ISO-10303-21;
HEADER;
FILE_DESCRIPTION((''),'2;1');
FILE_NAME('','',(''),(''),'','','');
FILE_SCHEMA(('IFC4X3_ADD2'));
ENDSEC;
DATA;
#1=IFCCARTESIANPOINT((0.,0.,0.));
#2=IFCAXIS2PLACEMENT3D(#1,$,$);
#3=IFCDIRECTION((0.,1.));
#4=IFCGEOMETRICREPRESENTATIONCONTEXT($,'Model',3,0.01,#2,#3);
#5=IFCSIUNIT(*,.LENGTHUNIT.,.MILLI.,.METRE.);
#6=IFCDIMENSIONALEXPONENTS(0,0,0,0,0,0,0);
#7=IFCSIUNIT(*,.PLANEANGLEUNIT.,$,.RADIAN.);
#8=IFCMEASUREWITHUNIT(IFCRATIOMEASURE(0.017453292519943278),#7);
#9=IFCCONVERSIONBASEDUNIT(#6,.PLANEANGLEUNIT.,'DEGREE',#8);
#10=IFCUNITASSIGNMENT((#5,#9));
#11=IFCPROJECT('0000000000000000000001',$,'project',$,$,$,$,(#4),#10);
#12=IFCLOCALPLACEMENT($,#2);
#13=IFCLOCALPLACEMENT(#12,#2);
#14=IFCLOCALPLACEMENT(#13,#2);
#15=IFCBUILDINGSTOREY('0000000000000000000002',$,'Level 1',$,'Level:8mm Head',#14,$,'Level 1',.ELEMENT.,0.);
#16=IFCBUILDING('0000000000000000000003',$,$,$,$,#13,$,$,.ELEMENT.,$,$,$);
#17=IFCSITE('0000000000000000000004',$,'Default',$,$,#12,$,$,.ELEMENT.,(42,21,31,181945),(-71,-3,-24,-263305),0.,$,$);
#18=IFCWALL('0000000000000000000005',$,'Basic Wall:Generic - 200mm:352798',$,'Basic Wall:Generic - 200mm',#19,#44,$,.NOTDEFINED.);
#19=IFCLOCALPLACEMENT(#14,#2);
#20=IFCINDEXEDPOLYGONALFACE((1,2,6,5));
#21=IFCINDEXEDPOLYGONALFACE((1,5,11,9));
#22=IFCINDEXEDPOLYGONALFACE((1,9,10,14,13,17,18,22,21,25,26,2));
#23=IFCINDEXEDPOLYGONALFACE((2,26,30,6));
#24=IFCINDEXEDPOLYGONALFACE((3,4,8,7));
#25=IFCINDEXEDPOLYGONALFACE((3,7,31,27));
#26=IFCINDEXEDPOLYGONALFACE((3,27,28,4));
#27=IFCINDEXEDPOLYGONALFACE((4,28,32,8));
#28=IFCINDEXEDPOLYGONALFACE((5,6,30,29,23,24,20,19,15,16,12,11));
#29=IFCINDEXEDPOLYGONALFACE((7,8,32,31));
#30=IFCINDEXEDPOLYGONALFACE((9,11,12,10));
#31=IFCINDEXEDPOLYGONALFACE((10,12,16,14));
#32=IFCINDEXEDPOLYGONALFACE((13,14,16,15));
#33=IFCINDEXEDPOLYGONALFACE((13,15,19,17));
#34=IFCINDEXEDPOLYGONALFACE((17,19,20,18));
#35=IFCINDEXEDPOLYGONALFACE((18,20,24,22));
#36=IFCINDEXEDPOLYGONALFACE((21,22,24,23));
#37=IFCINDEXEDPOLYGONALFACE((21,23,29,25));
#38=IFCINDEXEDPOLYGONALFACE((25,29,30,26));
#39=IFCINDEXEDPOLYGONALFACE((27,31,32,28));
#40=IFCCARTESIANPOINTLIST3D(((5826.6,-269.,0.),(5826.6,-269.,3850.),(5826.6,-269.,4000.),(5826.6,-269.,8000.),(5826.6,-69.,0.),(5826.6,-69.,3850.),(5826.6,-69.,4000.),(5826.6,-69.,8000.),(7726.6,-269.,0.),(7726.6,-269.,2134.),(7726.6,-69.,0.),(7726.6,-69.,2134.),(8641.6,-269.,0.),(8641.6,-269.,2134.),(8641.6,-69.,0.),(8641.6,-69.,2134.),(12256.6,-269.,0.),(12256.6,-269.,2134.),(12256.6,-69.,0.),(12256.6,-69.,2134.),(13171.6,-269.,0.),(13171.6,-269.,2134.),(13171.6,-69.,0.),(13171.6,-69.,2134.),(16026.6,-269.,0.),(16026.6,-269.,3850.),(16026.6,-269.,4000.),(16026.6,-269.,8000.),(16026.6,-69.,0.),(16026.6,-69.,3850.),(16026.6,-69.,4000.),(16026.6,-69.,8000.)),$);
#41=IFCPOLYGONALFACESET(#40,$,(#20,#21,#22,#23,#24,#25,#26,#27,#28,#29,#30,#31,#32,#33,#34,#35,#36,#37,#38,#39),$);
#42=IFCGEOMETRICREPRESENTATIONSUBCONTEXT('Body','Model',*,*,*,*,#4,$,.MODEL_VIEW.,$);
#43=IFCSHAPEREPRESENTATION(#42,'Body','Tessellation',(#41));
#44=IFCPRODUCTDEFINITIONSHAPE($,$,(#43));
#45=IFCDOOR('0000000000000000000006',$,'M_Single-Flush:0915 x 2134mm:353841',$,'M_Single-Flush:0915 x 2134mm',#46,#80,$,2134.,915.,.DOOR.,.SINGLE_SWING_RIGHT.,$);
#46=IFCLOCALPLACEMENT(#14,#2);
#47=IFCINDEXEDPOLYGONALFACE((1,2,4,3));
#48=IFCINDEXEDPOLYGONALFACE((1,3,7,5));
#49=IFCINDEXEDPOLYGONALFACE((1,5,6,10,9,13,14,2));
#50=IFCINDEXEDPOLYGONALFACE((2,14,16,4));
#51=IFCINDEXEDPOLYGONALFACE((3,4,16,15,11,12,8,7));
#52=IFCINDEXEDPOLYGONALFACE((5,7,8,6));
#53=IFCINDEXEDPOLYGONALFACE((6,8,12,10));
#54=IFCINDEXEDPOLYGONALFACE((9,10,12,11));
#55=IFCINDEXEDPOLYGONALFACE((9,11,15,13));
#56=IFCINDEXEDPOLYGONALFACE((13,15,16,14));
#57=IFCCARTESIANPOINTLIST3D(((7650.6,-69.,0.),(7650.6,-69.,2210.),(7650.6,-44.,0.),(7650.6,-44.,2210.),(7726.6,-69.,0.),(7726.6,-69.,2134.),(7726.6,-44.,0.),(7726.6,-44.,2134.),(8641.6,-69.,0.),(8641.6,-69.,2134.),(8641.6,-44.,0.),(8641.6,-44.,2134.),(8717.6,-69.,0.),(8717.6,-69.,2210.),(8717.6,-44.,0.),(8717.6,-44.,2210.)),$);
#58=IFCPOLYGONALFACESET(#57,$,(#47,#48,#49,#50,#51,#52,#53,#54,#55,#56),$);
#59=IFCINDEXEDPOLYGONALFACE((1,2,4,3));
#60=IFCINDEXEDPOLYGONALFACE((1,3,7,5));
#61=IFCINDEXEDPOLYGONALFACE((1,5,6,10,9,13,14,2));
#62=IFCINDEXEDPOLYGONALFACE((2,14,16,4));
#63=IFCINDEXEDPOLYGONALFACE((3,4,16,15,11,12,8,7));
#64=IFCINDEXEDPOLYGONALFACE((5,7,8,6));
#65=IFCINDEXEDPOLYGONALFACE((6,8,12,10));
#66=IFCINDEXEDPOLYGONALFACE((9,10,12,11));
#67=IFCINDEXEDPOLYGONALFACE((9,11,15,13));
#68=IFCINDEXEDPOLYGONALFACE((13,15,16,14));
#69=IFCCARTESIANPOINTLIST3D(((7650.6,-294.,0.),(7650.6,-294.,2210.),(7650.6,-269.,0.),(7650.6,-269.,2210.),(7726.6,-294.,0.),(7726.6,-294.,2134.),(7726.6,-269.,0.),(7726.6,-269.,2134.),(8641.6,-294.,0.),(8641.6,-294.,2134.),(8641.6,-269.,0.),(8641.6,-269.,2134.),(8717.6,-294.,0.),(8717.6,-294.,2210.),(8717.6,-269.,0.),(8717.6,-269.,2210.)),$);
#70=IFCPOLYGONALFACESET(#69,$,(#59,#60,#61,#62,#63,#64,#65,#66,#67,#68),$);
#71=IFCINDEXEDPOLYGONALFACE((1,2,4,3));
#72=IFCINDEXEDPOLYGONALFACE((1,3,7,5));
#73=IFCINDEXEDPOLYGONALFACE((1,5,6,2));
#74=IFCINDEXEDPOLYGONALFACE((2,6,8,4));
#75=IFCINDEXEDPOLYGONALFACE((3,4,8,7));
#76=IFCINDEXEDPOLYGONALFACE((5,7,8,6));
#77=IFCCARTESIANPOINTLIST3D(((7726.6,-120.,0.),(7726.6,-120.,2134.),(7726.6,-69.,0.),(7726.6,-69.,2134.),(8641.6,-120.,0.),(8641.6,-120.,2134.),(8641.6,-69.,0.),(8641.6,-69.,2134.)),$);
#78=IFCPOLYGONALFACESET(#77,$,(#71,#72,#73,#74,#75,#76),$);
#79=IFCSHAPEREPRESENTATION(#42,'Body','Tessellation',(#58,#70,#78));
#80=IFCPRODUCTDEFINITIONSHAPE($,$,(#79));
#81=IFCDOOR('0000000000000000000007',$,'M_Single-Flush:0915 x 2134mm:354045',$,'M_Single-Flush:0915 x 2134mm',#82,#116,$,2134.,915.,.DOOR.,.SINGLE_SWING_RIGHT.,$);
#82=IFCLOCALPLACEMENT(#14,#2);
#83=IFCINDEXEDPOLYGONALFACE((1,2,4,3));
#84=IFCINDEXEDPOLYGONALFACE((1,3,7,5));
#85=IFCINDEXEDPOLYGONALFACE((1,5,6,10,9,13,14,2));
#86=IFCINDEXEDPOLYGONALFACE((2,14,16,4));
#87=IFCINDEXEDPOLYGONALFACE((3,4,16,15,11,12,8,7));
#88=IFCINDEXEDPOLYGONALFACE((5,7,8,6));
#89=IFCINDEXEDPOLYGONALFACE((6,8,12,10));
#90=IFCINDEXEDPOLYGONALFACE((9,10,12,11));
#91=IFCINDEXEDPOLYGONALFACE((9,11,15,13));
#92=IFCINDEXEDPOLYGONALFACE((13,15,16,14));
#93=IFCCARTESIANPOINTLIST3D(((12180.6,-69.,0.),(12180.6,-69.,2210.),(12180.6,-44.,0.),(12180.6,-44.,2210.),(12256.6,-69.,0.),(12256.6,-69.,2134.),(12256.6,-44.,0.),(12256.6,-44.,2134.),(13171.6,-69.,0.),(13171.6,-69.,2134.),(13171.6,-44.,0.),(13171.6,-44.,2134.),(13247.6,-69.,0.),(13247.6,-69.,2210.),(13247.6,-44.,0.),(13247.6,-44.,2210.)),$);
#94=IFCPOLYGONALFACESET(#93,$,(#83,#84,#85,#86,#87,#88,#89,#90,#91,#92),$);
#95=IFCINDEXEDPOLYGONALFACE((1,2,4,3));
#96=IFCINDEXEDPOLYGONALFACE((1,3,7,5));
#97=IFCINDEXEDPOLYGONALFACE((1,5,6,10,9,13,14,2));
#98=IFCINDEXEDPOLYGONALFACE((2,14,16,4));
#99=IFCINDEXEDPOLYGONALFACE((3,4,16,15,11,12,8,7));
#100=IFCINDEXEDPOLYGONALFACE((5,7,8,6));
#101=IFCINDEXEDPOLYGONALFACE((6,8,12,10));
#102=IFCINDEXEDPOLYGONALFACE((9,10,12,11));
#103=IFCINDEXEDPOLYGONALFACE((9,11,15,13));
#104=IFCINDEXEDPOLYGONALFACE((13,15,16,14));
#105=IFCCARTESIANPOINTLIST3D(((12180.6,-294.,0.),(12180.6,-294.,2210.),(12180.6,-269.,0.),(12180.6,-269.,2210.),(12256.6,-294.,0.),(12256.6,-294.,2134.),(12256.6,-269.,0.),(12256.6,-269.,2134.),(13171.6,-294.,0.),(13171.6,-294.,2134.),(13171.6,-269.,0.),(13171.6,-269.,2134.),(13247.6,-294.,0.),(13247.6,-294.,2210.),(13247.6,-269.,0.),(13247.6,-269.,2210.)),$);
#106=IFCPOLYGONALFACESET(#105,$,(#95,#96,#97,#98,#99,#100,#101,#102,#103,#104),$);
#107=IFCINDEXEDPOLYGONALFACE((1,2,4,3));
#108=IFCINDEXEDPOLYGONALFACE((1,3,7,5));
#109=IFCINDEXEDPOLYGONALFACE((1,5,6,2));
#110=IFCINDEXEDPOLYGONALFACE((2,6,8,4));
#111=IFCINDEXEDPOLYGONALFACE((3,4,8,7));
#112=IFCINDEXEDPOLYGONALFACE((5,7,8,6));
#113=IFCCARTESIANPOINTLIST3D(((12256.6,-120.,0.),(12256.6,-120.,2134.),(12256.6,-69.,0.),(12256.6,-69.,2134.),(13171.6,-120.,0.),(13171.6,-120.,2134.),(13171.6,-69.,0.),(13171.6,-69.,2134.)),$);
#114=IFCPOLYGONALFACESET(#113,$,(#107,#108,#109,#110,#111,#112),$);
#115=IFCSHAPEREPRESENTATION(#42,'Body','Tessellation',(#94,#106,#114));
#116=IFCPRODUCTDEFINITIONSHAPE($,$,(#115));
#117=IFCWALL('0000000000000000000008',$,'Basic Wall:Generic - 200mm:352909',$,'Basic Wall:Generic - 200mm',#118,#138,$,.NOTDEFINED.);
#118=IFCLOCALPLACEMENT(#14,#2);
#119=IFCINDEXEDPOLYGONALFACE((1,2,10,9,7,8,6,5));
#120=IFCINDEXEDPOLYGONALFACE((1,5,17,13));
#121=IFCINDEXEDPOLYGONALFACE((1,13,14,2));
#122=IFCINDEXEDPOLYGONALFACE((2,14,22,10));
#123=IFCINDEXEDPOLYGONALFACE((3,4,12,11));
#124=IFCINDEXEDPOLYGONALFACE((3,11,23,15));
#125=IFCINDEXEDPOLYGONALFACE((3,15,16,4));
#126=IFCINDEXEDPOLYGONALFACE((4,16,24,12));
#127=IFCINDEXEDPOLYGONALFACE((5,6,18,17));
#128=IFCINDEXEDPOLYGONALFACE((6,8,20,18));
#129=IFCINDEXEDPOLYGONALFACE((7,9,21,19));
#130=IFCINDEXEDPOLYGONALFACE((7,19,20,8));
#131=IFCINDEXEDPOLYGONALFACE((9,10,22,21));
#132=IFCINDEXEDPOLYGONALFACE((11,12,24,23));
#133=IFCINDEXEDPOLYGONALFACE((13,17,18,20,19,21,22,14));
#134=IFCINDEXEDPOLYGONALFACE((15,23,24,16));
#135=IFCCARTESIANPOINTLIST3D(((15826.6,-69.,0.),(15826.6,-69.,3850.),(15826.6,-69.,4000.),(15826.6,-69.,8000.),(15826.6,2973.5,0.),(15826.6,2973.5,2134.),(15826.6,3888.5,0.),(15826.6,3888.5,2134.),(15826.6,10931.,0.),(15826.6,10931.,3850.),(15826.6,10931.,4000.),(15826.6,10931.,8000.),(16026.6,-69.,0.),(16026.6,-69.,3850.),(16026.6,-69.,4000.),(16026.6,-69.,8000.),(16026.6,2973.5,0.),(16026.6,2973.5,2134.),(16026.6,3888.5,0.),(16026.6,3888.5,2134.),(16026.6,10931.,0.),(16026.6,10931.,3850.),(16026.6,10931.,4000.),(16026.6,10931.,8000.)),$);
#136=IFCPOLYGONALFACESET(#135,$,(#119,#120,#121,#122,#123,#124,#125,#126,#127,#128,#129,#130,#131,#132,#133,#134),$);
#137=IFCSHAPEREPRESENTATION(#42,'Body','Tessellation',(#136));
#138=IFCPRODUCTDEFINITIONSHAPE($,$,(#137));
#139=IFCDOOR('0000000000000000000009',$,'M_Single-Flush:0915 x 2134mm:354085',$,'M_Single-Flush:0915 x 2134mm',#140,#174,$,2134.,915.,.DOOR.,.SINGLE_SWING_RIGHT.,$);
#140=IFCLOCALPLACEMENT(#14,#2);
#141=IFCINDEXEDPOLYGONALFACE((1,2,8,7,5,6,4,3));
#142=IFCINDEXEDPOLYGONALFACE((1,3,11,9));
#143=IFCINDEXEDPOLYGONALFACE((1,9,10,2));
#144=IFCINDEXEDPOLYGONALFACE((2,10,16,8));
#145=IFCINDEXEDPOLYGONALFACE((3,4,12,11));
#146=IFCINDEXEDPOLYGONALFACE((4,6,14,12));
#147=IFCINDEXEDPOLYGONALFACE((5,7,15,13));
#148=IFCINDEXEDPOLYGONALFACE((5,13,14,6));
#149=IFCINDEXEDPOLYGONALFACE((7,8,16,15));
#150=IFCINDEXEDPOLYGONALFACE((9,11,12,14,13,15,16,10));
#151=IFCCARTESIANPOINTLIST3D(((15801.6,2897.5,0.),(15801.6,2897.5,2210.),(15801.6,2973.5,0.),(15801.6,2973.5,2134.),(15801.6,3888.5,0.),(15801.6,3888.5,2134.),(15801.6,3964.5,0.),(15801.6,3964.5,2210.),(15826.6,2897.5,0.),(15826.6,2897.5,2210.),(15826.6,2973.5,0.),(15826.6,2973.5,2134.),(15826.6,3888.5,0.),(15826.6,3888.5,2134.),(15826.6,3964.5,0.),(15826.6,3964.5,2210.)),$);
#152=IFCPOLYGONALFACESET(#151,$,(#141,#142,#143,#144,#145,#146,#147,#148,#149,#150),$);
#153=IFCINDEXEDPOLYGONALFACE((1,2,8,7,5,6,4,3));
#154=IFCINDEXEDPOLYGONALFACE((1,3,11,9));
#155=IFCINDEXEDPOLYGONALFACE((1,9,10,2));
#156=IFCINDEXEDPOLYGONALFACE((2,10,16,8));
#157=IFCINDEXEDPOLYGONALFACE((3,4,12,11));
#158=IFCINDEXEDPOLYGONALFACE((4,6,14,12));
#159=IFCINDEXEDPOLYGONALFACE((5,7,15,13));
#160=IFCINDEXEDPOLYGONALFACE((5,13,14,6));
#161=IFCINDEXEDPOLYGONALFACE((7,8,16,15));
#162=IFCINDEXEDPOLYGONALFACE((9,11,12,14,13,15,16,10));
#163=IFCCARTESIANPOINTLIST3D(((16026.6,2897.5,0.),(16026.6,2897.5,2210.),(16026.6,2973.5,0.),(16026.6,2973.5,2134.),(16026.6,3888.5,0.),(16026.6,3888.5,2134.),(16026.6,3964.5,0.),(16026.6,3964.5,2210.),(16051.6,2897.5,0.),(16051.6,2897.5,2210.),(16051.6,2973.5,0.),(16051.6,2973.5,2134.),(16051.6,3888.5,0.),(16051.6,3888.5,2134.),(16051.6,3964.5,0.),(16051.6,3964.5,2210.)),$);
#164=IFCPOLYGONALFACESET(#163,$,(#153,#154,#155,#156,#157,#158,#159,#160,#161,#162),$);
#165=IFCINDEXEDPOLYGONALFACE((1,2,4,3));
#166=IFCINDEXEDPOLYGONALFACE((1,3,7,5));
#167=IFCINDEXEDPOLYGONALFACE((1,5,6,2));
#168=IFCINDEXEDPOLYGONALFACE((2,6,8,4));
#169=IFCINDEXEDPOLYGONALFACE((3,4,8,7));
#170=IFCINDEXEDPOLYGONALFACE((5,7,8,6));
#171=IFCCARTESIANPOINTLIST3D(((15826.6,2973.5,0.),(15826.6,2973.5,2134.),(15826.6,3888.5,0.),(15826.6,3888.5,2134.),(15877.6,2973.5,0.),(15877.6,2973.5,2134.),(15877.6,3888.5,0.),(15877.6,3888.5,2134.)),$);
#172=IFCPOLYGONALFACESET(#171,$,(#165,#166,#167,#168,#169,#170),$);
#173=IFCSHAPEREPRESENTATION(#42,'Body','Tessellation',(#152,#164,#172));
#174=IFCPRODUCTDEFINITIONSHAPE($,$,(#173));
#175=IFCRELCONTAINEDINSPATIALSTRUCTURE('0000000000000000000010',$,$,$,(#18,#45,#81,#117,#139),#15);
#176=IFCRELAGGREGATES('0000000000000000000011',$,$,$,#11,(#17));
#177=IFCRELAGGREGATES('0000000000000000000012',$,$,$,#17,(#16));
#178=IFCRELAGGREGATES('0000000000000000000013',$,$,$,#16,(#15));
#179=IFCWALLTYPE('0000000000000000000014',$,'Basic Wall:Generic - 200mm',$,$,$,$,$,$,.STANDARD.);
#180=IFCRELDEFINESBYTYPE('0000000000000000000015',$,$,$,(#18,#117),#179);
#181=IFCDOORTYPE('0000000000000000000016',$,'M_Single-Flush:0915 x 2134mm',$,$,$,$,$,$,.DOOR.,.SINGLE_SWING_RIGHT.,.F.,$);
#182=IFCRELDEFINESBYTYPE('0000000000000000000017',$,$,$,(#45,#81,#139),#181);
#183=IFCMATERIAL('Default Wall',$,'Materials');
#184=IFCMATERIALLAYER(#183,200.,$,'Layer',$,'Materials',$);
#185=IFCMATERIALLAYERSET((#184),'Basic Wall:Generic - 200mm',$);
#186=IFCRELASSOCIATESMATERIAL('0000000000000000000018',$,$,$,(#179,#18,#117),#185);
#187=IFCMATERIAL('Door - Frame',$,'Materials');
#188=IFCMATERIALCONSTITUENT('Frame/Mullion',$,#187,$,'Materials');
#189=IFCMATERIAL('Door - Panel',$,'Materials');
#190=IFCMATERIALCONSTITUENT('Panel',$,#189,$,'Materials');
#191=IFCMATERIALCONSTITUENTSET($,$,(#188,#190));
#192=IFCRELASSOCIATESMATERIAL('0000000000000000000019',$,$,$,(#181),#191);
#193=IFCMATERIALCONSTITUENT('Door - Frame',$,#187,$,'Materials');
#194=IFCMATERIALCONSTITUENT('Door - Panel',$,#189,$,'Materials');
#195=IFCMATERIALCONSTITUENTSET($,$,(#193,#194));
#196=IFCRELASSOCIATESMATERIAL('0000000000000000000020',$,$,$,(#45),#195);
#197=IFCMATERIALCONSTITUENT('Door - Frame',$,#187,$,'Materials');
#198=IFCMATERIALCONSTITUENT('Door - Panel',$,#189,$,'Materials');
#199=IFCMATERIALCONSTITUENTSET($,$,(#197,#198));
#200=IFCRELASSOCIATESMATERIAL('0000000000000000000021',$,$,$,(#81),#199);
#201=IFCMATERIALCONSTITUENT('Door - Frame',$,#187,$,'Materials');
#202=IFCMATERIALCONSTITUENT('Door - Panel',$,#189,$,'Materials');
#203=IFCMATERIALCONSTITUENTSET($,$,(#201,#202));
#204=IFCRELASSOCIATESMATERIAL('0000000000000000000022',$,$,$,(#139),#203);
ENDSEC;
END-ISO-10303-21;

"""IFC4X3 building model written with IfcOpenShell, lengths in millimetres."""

from ifc_helpers import new_model, entity, si_unit, converted_unit, direction, frame, frame_2d, origin, place, context, subcontext, project, spatial, polyline, rectangle, outline, extrude, source, transform, mapped, material, layer, layer_set, constituent, constituent_set, type_object, type_shapes, element, fill, save


model = new_model("IFC4X3")

# Units and contexts
model_context = context("Model", 3, precision=0.01, world=origin(), true_north=direction((0.0, 1.0)))
body_context = subcontext(model_context, "Body", "Model", "MODEL_VIEW")
ifc_project = project(units=[si_unit("LENGTHUNIT", "METRE", prefix="MILLI"), converted_unit("PLANEANGLEUNIT", "DEGREE", entity("IfcRatioMeasure", 0.017453292519943278), si_unit("PLANEANGLEUNIT", "RADIAN"), dimensions=[0, 0, 0, 0, 0, 0, 0])], contexts=[model_context])

# Site, building, storey
site_placement = place(None, origin())
site = spatial("IfcSite", under=ifc_project, at=site_placement, Name="Default", CompositionType="ELEMENT", RefLatitude=(42, 21, 31, 181945), RefLongitude=(-71, -3, -24, -263305), RefElevation=0.0)
building_placement = place(site_placement, origin())
building = spatial("IfcBuilding", under=site, at=building_placement, CompositionType="ELEMENT")
storey_placement = place(building_placement, origin())
storey = spatial("IfcBuildingStorey", under=building, at=storey_placement, Name="Level 1", ObjectType="Level:8mm Head", LongName="Level 1", CompositionType="ELEMENT", Elevation=0.0)

# Wall, openings, doors
ifc_material_1 = material(Name="Default Wall", Category="Materials")
ifc_layer_1 = layer(ifc_material_1, 200.0, Name="Layer", Category="Materials")
ifc_layer_set_1 = layer_set([ifc_layer_1], Name="Basic Wall:Generic - 200mm")
wall_type = type_object("IfcWallType", Name="Basic Wall:Generic - 200mm", PredefinedType="STANDARD", material=ifc_layer_set_1)
wall_1_placement = place(storey_placement, frame((5826.6, -169.0, 0.0)))
wall_1 = element("IfcWall", 1, at=wall_1_placement, inside=storey, type_object=wall_type, material=ifc_layer_set_1, Name="Basic Wall:Generic - 200mm:352798", ObjectType="Basic Wall:Generic - 200mm", PredefinedType="NOTDEFINED", context=body_context, shape_type="SweptSolid", body=[
    extrude(rectangle(XDim=10200.0, YDim=200.0, at=frame_2d((5100.0, 0.0), x_axis=(-1.0, 0.0))), origin(), (0.0, 0.0, 1.0), 8000.0),
])
opening_1_placement = place(storey_placement, frame((5826.6, -169.0, 0.0)))
element("IfcOpeningElement", 2, at=opening_1_placement, cuts=wall_1, PredefinedType="OPENING", context=body_context, shape_type="SweptSolid", body=[
    extrude(rectangle(XDim=10200.0, YDim=200.0, at=frame_2d((0.0, -33.3), x_axis=(1.0, 0.0))), frame((5100.0, 33.3, 3850.0)), (0.0, 0.0, 1.0), 150.0),
])
opening_2_placement = place(wall_1_placement, frame((1900.0, -100.0, 0.0)))
opening_2 = element("IfcOpeningElement", 3, at=opening_2_placement, cuts=wall_1, PredefinedType="OPENING", context=body_context, shape_type="SweptSolid", body=[
    extrude(rectangle(XDim=915.0, YDim=2134.0, at=frame_2d((1067.0, 457.5), x_axis=(0.0, 1.0))), frame((0.0, 0.0, 0.0), z_axis=(0.0, 1.0, 0.0), x_axis=(0.0, 0.0, 1.0)), (0.0, 0.0, 1.0), 200.0),
])
opening_3_placement = place(wall_1_placement, frame((6430.0, -100.0, 0.0)))
opening_3 = element("IfcOpeningElement", 4, at=opening_3_placement, cuts=wall_1, PredefinedType="OPENING", context=body_context, shape_type="SweptSolid", body=[
    extrude(rectangle(XDim=915.0, YDim=2134.0, at=frame_2d((1067.0, 457.5), x_axis=(0.0, 1.0))), frame((0.0, 0.0, 0.0), z_axis=(0.0, 1.0, 0.0), x_axis=(0.0, 0.0, 1.0)), (0.0, 0.0, 1.0), 200.0),
])
ifc_material_2 = material(Name="Door - Frame", Category="Materials")
ifc_constituent_1 = constituent(ifc_material_2, Name="Door - Frame", Category="Materials")
ifc_material_3 = material(Name="Door - Panel", Category="Materials")
ifc_constituent_2 = constituent(ifc_material_3, Name="Door - Panel", Category="Materials")
ifc_constituent_set_1 = constituent_set(constituents=[ifc_constituent_1, ifc_constituent_2])
ifc_constituent_3 = constituent(ifc_material_2, Name="Frame/Mullion", Category="Materials")
ifc_constituent_4 = constituent(ifc_material_3, Name="Panel", Category="Materials")
ifc_constituent_set_2 = constituent_set(constituents=[ifc_constituent_3, ifc_constituent_4])
door_type = type_object("IfcDoorType", Name="M_Single-Flush:0915 x 2134mm", OperationType="SINGLE_SWING_RIGHT", ParameterTakesPrecedence=False, PredefinedType="DOOR", material=ifc_constituent_set_2)
shared_shape = source(origin(), body_context, "Body", "SweptSolid", [
    extrude(outline(polyline([(-533.5, -1124.0), (533.5, -1124.0), (533.5, 1086.0), (457.5, 1086.0), (457.5, -1048.0), (-457.5, -1048.0), (-457.5, 1086.0), (-533.5, 1086.0), (-533.5, -1124.0)])), frame((457.5, 200.0, 1086.0), z_axis=(0.0, 1.0, 0.0), x_axis=(1.0, 0.0, 0.0)), (0.0, 0.0, 1.0), 25.0),
    extrude(outline(polyline([(-1124.0, -533.5), (1086.0, -533.5), (1086.0, -457.5), (-1048.0, -457.5), (-1048.0, 457.5), (1086.0, 457.5), (1086.0, 533.5), (-1124.0, 533.5), (-1124.0, -533.5)])), frame((457.5, -25.0, 1086.0), z_axis=(0.0, 1.0, 0.0), x_axis=(0.0, 0.0, -1.0)), (0.0, 0.0, 1.0), 25.0),
    extrude(rectangle(XDim=51.0, YDim=915.0, at=frame_2d((0.0, 0.0), x_axis=(1.0, 0.0))), frame((457.5, 174.5, 0.0), z_axis=(0.0, 0.0, 1.0), x_axis=(0.0, 1.0, 0.0)), (0.0, 0.0, 1.0), 2134.0),
])
type_shapes(door_type, [shared_shape])
door_1_placement = place(opening_2_placement, origin())
door_1 = element("IfcDoor", 5, at=door_1_placement, inside=storey, type_object=door_type, material=ifc_constituent_set_1, Name="M_Single-Flush:0915 x 2134mm:353841", ObjectType="M_Single-Flush:0915 x 2134mm", OperationType="SINGLE_SWING_RIGHT", OverallHeight=2134.0, OverallWidth=915.0, PredefinedType="DOOR", context=body_context, shape_type="MappedRepresentation", body=[
    mapped(shared_shape, transform((0.0, 0.0, 0.0), scale=1.0)),
])
fill(opening_2, door_1)
ifc_constituent_5 = constituent(ifc_material_2, Name="Door - Frame", Category="Materials")
ifc_constituent_6 = constituent(ifc_material_3, Name="Door - Panel", Category="Materials")
ifc_constituent_set_3 = constituent_set(constituents=[ifc_constituent_5, ifc_constituent_6])
door_2_placement = place(opening_3_placement, origin())
door_2 = element("IfcDoor", 6, at=door_2_placement, inside=storey, type_object=door_type, material=ifc_constituent_set_3, Name="M_Single-Flush:0915 x 2134mm:354045", ObjectType="M_Single-Flush:0915 x 2134mm", OperationType="SINGLE_SWING_RIGHT", OverallHeight=2134.0, OverallWidth=915.0, PredefinedType="DOOR", context=body_context, shape_type="MappedRepresentation", body=[
    mapped(shared_shape, transform((0.0, 0.0, 0.0), scale=1.0)),
])
fill(opening_3, door_2)

# Wall, openings, door
wall_2_placement = place(storey_placement, frame((15926.6, -69.0, 0.0), z_axis=(0.0, 0.0, 1.0), x_axis=(0.0, 1.0, 0.0)))
wall_2 = element("IfcWall", 7, at=wall_2_placement, inside=storey, type_object=wall_type, material=ifc_layer_set_1, Name="Basic Wall:Generic - 200mm:352909", ObjectType="Basic Wall:Generic - 200mm", PredefinedType="NOTDEFINED", context=body_context, shape_type="SweptSolid", body=[
    extrude(rectangle(XDim=11000.0, YDim=200.0, at=frame_2d((5500.0, 0.0), x_axis=(1.0, 0.0))), origin(), (0.0, 0.0, 1.0), 8000.0),
])
opening_4_placement = place(storey_placement, frame((15926.6, -69.0, 0.0), z_axis=(0.0, 0.0, 1.0), x_axis=(0.0, 1.0, 0.0)))
element("IfcOpeningElement", 8, at=opening_4_placement, cuts=wall_2, PredefinedType="OPENING", context=body_context, shape_type="SweptSolid", body=[
    extrude(rectangle(XDim=11000.0, YDim=200.0, at=frame_2d((-1214.3, -42.9), x_axis=(1.0, 0.0))), frame((6714.3, 42.9, 3850.0)), (0.0, 0.0, 1.0), 150.0),
])
opening_5_placement = place(wall_2_placement, frame((3042.5, -100.0, 0.0)))
opening_5 = element("IfcOpeningElement", 9, at=opening_5_placement, cuts=wall_2, PredefinedType="OPENING", context=body_context, shape_type="SweptSolid", body=[
    extrude(rectangle(XDim=915.0, YDim=2134.0, at=frame_2d((1067.0, 457.5), x_axis=(0.0, 1.0))), frame((0.0, 0.0, 0.0), z_axis=(0.0, 1.0, 0.0), x_axis=(0.0, 0.0, 1.0)), (0.0, 0.0, 1.0), 200.0),
])
ifc_constituent_7 = constituent(ifc_material_2, Name="Door - Frame", Category="Materials")
ifc_constituent_8 = constituent(ifc_material_3, Name="Door - Panel", Category="Materials")
ifc_constituent_set_4 = constituent_set(constituents=[ifc_constituent_7, ifc_constituent_8])
door_3_placement = place(opening_5_placement, origin())
door_3 = element("IfcDoor", 10, at=door_3_placement, inside=storey, type_object=door_type, material=ifc_constituent_set_4, Name="M_Single-Flush:0915 x 2134mm:354085", ObjectType="M_Single-Flush:0915 x 2134mm", OperationType="SINGLE_SWING_RIGHT", OverallHeight=2134.0, OverallWidth=915.0, PredefinedType="DOOR", context=body_context, shape_type="MappedRepresentation", body=[
    mapped(shared_shape, transform((0.0, 0.0, 0.0), scale=1.0)),
])
fill(opening_5, door_3)

save(model, "model.ifc")
